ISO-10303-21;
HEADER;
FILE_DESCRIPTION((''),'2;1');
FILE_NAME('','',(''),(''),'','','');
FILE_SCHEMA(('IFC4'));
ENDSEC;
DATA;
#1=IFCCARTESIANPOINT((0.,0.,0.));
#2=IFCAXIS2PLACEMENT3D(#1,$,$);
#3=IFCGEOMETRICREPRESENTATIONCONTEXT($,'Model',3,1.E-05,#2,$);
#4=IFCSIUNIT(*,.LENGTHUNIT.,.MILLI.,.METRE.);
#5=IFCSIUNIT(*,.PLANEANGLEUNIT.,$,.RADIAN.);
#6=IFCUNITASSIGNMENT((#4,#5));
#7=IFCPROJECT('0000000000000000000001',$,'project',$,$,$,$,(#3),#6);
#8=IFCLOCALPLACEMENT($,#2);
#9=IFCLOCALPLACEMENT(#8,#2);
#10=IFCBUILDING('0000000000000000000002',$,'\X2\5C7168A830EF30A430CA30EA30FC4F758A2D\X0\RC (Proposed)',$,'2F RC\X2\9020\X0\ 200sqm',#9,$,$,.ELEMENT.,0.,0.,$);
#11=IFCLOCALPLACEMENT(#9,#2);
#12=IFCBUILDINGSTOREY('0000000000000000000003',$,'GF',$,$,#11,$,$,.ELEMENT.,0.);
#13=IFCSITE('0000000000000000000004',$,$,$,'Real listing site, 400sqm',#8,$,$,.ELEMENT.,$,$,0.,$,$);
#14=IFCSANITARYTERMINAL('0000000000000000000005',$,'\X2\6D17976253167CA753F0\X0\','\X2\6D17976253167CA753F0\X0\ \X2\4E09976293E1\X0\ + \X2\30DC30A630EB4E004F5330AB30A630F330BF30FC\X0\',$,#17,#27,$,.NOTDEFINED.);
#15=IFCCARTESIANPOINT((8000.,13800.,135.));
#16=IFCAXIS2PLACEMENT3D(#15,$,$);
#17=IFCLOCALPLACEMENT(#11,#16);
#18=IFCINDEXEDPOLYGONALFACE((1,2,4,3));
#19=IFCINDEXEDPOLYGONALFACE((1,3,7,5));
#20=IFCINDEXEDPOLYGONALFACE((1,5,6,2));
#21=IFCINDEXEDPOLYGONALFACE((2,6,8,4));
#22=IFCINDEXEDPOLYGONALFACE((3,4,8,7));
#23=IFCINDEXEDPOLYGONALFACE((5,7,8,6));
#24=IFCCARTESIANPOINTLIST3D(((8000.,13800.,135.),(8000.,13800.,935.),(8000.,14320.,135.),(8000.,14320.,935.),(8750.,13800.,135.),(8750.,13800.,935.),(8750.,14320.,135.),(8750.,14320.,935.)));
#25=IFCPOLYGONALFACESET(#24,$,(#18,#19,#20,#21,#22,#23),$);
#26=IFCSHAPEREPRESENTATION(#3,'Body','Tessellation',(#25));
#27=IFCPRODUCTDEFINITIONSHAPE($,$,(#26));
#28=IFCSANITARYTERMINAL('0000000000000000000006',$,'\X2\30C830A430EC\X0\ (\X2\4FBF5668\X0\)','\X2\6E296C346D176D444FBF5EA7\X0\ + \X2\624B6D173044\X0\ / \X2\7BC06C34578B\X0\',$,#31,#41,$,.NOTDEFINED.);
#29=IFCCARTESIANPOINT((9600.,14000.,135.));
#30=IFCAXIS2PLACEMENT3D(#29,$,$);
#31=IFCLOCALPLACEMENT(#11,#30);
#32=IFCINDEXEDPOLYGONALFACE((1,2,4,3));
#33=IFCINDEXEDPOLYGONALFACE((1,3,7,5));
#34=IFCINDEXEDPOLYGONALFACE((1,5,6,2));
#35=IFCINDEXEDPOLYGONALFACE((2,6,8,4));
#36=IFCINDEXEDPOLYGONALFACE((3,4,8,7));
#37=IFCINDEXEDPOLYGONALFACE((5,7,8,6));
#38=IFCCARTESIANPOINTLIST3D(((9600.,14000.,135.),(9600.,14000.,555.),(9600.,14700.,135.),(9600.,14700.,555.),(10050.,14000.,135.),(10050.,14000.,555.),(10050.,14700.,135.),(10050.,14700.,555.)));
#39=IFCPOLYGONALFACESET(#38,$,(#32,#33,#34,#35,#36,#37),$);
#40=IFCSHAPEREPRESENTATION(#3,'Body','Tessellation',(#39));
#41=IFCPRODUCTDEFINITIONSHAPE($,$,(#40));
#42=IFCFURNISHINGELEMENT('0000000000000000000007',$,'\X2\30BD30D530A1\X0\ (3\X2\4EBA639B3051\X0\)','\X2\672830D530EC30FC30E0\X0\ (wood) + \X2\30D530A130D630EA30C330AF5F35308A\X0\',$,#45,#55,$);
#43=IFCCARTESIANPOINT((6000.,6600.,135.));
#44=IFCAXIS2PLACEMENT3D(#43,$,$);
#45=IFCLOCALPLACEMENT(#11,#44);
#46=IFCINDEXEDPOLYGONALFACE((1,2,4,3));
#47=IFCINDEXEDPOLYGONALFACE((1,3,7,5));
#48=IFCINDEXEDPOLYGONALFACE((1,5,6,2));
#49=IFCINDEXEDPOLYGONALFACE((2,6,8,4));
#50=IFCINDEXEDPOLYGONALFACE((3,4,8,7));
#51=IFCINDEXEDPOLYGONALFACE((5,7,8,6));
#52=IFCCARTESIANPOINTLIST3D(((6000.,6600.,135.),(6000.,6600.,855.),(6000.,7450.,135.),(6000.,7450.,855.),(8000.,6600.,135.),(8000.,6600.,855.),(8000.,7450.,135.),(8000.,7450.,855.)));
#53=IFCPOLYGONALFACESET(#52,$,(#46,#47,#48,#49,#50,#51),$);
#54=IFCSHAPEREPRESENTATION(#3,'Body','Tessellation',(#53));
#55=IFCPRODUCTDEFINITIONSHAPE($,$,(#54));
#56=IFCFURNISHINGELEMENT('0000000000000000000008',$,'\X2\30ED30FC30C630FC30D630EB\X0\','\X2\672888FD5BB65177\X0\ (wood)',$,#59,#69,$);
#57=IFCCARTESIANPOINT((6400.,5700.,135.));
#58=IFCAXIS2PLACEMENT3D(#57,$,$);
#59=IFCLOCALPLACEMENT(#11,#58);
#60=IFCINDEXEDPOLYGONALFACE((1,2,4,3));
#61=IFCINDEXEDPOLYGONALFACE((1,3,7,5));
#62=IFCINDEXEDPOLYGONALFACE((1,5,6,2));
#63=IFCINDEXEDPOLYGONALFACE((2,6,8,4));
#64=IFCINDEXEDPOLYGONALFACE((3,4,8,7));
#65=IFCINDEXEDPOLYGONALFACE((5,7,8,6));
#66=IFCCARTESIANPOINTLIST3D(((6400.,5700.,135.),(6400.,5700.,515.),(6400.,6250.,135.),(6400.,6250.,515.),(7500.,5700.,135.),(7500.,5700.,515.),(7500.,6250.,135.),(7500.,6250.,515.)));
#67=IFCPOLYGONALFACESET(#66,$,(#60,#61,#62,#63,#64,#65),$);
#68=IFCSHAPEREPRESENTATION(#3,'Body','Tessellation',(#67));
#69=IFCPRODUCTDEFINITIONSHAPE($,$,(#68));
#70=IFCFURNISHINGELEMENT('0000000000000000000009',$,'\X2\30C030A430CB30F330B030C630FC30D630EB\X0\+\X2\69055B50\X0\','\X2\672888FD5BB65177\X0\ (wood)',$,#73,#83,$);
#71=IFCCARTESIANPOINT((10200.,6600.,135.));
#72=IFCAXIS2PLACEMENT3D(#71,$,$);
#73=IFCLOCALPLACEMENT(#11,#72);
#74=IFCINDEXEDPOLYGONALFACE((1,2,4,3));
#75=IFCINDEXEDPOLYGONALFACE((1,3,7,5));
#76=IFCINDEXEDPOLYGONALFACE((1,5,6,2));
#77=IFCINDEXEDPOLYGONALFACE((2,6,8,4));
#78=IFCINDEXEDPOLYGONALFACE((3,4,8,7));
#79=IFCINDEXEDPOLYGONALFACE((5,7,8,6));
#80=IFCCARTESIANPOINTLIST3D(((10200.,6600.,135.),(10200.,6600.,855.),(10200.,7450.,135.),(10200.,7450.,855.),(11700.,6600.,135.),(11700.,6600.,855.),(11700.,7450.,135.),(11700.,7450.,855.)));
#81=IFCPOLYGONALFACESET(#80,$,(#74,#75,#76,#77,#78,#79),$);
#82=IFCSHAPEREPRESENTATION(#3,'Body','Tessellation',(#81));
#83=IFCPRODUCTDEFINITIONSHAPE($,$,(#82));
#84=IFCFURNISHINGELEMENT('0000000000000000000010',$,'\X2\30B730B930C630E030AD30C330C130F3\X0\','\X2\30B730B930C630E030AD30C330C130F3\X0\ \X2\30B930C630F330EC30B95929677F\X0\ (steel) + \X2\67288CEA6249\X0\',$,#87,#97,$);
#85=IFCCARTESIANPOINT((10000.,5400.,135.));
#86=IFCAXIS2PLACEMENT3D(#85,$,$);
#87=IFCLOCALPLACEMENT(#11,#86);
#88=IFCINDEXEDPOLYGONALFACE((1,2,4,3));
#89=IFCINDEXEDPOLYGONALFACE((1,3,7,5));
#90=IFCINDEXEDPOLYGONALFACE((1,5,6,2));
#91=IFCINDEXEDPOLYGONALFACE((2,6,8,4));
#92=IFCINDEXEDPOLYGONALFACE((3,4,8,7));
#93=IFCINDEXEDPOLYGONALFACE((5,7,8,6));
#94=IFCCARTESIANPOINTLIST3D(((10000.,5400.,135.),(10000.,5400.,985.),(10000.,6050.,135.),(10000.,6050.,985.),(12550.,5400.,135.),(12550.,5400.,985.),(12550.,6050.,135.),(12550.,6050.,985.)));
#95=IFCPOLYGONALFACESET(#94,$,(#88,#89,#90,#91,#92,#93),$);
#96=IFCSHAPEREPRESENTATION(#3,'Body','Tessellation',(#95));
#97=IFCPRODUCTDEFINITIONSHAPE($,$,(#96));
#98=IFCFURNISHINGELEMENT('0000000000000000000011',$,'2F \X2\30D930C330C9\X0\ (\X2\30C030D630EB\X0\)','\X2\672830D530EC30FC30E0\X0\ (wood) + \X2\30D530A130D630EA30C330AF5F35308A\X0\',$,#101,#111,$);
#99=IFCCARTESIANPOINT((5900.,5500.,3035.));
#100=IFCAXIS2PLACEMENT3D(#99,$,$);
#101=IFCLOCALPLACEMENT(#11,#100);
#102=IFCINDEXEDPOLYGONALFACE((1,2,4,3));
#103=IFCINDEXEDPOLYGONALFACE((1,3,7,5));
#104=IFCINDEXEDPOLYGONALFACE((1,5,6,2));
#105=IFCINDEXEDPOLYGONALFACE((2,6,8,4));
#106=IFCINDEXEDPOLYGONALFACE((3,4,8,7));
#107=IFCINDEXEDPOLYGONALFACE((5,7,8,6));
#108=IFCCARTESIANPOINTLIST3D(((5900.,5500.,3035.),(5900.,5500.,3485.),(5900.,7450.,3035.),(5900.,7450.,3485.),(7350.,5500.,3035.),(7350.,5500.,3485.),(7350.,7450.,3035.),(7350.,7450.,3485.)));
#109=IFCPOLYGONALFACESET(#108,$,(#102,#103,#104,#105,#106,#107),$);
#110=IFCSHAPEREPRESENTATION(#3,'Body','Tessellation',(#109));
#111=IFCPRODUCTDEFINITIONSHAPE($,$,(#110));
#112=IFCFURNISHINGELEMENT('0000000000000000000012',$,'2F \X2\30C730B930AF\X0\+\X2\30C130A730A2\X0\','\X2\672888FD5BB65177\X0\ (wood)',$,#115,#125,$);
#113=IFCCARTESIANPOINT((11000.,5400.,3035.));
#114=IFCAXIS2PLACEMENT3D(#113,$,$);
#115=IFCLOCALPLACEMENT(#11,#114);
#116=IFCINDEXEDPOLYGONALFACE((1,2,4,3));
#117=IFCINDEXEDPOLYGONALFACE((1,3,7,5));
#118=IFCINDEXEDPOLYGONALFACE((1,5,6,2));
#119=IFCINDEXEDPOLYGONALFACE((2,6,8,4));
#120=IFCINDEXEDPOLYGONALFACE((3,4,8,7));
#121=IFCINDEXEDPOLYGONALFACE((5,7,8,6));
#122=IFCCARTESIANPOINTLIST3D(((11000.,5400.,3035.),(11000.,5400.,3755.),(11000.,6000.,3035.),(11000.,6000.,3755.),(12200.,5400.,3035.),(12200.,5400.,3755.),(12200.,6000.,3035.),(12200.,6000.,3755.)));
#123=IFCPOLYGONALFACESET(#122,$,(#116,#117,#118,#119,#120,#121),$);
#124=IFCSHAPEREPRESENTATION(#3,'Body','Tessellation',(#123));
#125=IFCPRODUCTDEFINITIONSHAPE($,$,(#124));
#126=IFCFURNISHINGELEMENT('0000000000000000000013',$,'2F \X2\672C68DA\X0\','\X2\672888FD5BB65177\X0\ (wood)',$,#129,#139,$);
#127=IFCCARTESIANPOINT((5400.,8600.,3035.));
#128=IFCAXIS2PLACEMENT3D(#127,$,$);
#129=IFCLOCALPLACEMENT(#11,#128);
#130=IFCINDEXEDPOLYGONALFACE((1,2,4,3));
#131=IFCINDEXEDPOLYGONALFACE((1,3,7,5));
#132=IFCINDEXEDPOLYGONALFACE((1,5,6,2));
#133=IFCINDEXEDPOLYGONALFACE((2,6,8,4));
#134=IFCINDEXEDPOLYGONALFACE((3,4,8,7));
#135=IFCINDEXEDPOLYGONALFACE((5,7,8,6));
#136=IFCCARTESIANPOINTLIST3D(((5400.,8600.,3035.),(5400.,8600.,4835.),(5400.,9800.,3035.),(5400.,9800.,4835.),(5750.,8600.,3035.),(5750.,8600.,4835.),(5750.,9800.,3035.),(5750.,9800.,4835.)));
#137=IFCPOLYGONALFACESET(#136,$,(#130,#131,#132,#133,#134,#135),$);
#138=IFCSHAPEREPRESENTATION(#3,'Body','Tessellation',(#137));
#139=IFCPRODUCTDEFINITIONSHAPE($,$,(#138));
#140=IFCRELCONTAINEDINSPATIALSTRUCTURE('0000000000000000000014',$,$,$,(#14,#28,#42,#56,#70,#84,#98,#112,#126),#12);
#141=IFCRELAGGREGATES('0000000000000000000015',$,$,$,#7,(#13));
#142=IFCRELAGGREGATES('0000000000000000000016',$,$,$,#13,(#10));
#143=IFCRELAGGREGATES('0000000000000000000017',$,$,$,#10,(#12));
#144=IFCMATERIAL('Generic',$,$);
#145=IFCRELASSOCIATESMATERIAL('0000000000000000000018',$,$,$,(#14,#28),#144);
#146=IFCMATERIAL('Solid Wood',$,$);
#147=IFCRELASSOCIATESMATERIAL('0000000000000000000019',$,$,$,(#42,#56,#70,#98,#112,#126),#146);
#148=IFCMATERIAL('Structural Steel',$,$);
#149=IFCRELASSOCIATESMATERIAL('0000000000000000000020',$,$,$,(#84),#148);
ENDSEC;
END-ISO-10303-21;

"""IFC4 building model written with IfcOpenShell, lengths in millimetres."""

from ifc_helpers import new_model, si_unit, frame, frame_2d, origin, place, context, project, spatial, rectangle, extrude, material, element, save


model = new_model("IFC4")

# Units and contexts
model_context = context("Model", 3, precision=1e-05, world=origin())
ifc_project = project(units=[si_unit("LENGTHUNIT", "METRE", prefix="MILLI"), si_unit("PLANEANGLEUNIT", "RADIAN")], contexts=[model_context])

# Site, building, storey
site_placement = place(None, origin())
site = spatial("IfcSite", under=ifc_project, at=site_placement, ObjectType="Real listing site, 400sqm", CompositionType="ELEMENT", RefElevation=0.0)
building_placement = place(site_placement, origin())
building = spatial("IfcBuilding", under=site, at=building_placement, Name="山梨ワイナリー併設RC (Proposed)", ObjectType="2F RC造 200sqm", CompositionType="ELEMENT", ElevationOfRefHeight=0.0, ElevationOfTerrain=0.0)
storey_placement = place(building_placement, origin())
storey = spatial("IfcBuildingStorey", under=building, at=storey_placement, Name="GF", CompositionType="ELEMENT", Elevation=0.0)

# Shared definitions
ifc_material_1 = material(Name="Solid Wood")

# Shared definitions
ifc_material_2 = material(Name="Structural Steel")

# Shared definitions
ifc_material_3 = material(Name="Generic")

# Sanitary terminals
sanitary_terminal_1_placement = place(storey_placement, frame((8000.0, 13800.0, 135.0)))
element("IfcSanitaryTerminal", 1, at=sanitary_terminal_1_placement, inside=storey, material=ifc_material_3, Name="洗面化粧台", Description="洗面化粧台 三面鏡 + ボウル一体カウンター", PredefinedType="NOTDEFINED", context=model_context, shape_type="SweptSolid", body=[
    extrude(rectangle(XDim=750.0, YDim=520.0, at=frame_2d((375.0, 260.0))), frame((8000.0, 13800.0, 135.0)), (0.0, 0.0, 1.0), 800.0),
])
sanitary_terminal_2_placement = place(storey_placement, frame((9600.0, 14000.0, 135.0)))
element("IfcSanitaryTerminal", 2, at=sanitary_terminal_2_placement, inside=storey, material=ifc_material_3, Name="トイレ (便器)", Description="温水洗浄便座 + 手洗い / 節水型", PredefinedType="NOTDEFINED", context=model_context, shape_type="SweptSolid", body=[
    extrude(rectangle(XDim=450.0, YDim=700.0, at=frame_2d((225.0, 350.0))), frame((9600.0, 14000.0, 135.0)), (0.0, 0.0, 1.0), 420.0),
])

# Furnishing elements
furnishing_1_placement = place(storey_placement, frame((6000.0, 6600.0, 135.0)))
element("IfcFurnishingElement", 3, at=furnishing_1_placement, inside=storey, material=ifc_material_1, Name="ソファ (3人掛け)", Description="木フレーム (wood) + ファブリック張り", context=model_context, shape_type="SweptSolid", body=[
    extrude(rectangle(XDim=2000.0, YDim=850.0, at=frame_2d((1000.0, 425.0))), frame((6000.0, 6600.0, 135.0)), (0.0, 0.0, 1.0), 720.0),
])
furnishing_2_placement = place(storey_placement, frame((6400.0, 5700.0, 135.0)))
element("IfcFurnishingElement", 4, at=furnishing_2_placement, inside=storey, material=ifc_material_1, Name="ローテーブル", Description="木製家具 (wood)", context=model_context, shape_type="SweptSolid", body=[
    extrude(rectangle(XDim=1100.0, YDim=550.0, at=frame_2d((550.0, 275.0))), frame((6400.0, 5700.0, 135.0)), (0.0, 0.0, 1.0), 380.0),
])
furnishing_3_placement = place(storey_placement, frame((10200.0, 6600.0, 135.0)))
element("IfcFurnishingElement", 5, at=furnishing_3_placement, inside=storey, material=ifc_material_1, Name="ダイニングテーブル+椅子", Description="木製家具 (wood)", context=model_context, shape_type="SweptSolid", body=[
    extrude(rectangle(XDim=1500.0, YDim=850.0, at=frame_2d((750.0, 425.0))), frame((10200.0, 6600.0, 135.0)), (0.0, 0.0, 1.0), 720.0),
])
furnishing_4_placement = place(storey_placement, frame((10000.0, 5400.0, 135.0)))
element("IfcFurnishingElement", 6, at=furnishing_4_placement, inside=storey, material=ifc_material_2, Name="システムキッチン", Description="システムキッチン ステンレス天板 (steel) + 木質扉", context=model_context, shape_type="SweptSolid", body=[
    extrude(rectangle(XDim=2550.0, YDim=650.0, at=frame_2d((1275.0, 325.0))), frame((10000.0, 5400.0, 135.0)), (0.0, 0.0, 1.0), 850.0),
])
furnishing_5_placement = place(storey_placement, frame((5900.0, 5500.0, 3035.0)))
element("IfcFurnishingElement", 7, at=furnishing_5_placement, inside=storey, material=ifc_material_1, Name="2F ベッド (ダブル)", Description="木フレーム (wood) + ファブリック張り", context=model_context, shape_type="SweptSolid", body=[
    extrude(rectangle(XDim=1450.0, YDim=1950.0, at=frame_2d((725.0, 975.0))), frame((5900.0, 5500.0, 3035.0)), (0.0, 0.0, 1.0), 450.0),
])
furnishing_6_placement = place(storey_placement, frame((11000.0, 5400.0, 3035.0)))
element("IfcFurnishingElement", 8, at=furnishing_6_placement, inside=storey, material=ifc_material_1, Name="2F デスク+チェア", Description="木製家具 (wood)", context=model_context, shape_type="SweptSolid", body=[
    extrude(rectangle(XDim=1200.0, YDim=600.0, at=frame_2d((600.0, 300.0))), frame((11000.0, 5400.0, 3035.0)), (0.0, 0.0, 1.0), 720.0),
])
furnishing_7_placement = place(storey_placement, frame((5400.0, 8600.0, 3035.0)))
element("IfcFurnishingElement", 9, at=furnishing_7_placement, inside=storey, material=ifc_material_1, Name="2F 本棚", Description="木製家具 (wood)", context=model_context, shape_type="SweptSolid", body=[
    extrude(rectangle(XDim=350.0, YDim=1200.0, at=frame_2d((175.0, 600.0))), frame((5400.0, 8600.0, 3035.0)), (0.0, 0.0, 1.0), 1800.0),
])

save(model, "model.ifc")
